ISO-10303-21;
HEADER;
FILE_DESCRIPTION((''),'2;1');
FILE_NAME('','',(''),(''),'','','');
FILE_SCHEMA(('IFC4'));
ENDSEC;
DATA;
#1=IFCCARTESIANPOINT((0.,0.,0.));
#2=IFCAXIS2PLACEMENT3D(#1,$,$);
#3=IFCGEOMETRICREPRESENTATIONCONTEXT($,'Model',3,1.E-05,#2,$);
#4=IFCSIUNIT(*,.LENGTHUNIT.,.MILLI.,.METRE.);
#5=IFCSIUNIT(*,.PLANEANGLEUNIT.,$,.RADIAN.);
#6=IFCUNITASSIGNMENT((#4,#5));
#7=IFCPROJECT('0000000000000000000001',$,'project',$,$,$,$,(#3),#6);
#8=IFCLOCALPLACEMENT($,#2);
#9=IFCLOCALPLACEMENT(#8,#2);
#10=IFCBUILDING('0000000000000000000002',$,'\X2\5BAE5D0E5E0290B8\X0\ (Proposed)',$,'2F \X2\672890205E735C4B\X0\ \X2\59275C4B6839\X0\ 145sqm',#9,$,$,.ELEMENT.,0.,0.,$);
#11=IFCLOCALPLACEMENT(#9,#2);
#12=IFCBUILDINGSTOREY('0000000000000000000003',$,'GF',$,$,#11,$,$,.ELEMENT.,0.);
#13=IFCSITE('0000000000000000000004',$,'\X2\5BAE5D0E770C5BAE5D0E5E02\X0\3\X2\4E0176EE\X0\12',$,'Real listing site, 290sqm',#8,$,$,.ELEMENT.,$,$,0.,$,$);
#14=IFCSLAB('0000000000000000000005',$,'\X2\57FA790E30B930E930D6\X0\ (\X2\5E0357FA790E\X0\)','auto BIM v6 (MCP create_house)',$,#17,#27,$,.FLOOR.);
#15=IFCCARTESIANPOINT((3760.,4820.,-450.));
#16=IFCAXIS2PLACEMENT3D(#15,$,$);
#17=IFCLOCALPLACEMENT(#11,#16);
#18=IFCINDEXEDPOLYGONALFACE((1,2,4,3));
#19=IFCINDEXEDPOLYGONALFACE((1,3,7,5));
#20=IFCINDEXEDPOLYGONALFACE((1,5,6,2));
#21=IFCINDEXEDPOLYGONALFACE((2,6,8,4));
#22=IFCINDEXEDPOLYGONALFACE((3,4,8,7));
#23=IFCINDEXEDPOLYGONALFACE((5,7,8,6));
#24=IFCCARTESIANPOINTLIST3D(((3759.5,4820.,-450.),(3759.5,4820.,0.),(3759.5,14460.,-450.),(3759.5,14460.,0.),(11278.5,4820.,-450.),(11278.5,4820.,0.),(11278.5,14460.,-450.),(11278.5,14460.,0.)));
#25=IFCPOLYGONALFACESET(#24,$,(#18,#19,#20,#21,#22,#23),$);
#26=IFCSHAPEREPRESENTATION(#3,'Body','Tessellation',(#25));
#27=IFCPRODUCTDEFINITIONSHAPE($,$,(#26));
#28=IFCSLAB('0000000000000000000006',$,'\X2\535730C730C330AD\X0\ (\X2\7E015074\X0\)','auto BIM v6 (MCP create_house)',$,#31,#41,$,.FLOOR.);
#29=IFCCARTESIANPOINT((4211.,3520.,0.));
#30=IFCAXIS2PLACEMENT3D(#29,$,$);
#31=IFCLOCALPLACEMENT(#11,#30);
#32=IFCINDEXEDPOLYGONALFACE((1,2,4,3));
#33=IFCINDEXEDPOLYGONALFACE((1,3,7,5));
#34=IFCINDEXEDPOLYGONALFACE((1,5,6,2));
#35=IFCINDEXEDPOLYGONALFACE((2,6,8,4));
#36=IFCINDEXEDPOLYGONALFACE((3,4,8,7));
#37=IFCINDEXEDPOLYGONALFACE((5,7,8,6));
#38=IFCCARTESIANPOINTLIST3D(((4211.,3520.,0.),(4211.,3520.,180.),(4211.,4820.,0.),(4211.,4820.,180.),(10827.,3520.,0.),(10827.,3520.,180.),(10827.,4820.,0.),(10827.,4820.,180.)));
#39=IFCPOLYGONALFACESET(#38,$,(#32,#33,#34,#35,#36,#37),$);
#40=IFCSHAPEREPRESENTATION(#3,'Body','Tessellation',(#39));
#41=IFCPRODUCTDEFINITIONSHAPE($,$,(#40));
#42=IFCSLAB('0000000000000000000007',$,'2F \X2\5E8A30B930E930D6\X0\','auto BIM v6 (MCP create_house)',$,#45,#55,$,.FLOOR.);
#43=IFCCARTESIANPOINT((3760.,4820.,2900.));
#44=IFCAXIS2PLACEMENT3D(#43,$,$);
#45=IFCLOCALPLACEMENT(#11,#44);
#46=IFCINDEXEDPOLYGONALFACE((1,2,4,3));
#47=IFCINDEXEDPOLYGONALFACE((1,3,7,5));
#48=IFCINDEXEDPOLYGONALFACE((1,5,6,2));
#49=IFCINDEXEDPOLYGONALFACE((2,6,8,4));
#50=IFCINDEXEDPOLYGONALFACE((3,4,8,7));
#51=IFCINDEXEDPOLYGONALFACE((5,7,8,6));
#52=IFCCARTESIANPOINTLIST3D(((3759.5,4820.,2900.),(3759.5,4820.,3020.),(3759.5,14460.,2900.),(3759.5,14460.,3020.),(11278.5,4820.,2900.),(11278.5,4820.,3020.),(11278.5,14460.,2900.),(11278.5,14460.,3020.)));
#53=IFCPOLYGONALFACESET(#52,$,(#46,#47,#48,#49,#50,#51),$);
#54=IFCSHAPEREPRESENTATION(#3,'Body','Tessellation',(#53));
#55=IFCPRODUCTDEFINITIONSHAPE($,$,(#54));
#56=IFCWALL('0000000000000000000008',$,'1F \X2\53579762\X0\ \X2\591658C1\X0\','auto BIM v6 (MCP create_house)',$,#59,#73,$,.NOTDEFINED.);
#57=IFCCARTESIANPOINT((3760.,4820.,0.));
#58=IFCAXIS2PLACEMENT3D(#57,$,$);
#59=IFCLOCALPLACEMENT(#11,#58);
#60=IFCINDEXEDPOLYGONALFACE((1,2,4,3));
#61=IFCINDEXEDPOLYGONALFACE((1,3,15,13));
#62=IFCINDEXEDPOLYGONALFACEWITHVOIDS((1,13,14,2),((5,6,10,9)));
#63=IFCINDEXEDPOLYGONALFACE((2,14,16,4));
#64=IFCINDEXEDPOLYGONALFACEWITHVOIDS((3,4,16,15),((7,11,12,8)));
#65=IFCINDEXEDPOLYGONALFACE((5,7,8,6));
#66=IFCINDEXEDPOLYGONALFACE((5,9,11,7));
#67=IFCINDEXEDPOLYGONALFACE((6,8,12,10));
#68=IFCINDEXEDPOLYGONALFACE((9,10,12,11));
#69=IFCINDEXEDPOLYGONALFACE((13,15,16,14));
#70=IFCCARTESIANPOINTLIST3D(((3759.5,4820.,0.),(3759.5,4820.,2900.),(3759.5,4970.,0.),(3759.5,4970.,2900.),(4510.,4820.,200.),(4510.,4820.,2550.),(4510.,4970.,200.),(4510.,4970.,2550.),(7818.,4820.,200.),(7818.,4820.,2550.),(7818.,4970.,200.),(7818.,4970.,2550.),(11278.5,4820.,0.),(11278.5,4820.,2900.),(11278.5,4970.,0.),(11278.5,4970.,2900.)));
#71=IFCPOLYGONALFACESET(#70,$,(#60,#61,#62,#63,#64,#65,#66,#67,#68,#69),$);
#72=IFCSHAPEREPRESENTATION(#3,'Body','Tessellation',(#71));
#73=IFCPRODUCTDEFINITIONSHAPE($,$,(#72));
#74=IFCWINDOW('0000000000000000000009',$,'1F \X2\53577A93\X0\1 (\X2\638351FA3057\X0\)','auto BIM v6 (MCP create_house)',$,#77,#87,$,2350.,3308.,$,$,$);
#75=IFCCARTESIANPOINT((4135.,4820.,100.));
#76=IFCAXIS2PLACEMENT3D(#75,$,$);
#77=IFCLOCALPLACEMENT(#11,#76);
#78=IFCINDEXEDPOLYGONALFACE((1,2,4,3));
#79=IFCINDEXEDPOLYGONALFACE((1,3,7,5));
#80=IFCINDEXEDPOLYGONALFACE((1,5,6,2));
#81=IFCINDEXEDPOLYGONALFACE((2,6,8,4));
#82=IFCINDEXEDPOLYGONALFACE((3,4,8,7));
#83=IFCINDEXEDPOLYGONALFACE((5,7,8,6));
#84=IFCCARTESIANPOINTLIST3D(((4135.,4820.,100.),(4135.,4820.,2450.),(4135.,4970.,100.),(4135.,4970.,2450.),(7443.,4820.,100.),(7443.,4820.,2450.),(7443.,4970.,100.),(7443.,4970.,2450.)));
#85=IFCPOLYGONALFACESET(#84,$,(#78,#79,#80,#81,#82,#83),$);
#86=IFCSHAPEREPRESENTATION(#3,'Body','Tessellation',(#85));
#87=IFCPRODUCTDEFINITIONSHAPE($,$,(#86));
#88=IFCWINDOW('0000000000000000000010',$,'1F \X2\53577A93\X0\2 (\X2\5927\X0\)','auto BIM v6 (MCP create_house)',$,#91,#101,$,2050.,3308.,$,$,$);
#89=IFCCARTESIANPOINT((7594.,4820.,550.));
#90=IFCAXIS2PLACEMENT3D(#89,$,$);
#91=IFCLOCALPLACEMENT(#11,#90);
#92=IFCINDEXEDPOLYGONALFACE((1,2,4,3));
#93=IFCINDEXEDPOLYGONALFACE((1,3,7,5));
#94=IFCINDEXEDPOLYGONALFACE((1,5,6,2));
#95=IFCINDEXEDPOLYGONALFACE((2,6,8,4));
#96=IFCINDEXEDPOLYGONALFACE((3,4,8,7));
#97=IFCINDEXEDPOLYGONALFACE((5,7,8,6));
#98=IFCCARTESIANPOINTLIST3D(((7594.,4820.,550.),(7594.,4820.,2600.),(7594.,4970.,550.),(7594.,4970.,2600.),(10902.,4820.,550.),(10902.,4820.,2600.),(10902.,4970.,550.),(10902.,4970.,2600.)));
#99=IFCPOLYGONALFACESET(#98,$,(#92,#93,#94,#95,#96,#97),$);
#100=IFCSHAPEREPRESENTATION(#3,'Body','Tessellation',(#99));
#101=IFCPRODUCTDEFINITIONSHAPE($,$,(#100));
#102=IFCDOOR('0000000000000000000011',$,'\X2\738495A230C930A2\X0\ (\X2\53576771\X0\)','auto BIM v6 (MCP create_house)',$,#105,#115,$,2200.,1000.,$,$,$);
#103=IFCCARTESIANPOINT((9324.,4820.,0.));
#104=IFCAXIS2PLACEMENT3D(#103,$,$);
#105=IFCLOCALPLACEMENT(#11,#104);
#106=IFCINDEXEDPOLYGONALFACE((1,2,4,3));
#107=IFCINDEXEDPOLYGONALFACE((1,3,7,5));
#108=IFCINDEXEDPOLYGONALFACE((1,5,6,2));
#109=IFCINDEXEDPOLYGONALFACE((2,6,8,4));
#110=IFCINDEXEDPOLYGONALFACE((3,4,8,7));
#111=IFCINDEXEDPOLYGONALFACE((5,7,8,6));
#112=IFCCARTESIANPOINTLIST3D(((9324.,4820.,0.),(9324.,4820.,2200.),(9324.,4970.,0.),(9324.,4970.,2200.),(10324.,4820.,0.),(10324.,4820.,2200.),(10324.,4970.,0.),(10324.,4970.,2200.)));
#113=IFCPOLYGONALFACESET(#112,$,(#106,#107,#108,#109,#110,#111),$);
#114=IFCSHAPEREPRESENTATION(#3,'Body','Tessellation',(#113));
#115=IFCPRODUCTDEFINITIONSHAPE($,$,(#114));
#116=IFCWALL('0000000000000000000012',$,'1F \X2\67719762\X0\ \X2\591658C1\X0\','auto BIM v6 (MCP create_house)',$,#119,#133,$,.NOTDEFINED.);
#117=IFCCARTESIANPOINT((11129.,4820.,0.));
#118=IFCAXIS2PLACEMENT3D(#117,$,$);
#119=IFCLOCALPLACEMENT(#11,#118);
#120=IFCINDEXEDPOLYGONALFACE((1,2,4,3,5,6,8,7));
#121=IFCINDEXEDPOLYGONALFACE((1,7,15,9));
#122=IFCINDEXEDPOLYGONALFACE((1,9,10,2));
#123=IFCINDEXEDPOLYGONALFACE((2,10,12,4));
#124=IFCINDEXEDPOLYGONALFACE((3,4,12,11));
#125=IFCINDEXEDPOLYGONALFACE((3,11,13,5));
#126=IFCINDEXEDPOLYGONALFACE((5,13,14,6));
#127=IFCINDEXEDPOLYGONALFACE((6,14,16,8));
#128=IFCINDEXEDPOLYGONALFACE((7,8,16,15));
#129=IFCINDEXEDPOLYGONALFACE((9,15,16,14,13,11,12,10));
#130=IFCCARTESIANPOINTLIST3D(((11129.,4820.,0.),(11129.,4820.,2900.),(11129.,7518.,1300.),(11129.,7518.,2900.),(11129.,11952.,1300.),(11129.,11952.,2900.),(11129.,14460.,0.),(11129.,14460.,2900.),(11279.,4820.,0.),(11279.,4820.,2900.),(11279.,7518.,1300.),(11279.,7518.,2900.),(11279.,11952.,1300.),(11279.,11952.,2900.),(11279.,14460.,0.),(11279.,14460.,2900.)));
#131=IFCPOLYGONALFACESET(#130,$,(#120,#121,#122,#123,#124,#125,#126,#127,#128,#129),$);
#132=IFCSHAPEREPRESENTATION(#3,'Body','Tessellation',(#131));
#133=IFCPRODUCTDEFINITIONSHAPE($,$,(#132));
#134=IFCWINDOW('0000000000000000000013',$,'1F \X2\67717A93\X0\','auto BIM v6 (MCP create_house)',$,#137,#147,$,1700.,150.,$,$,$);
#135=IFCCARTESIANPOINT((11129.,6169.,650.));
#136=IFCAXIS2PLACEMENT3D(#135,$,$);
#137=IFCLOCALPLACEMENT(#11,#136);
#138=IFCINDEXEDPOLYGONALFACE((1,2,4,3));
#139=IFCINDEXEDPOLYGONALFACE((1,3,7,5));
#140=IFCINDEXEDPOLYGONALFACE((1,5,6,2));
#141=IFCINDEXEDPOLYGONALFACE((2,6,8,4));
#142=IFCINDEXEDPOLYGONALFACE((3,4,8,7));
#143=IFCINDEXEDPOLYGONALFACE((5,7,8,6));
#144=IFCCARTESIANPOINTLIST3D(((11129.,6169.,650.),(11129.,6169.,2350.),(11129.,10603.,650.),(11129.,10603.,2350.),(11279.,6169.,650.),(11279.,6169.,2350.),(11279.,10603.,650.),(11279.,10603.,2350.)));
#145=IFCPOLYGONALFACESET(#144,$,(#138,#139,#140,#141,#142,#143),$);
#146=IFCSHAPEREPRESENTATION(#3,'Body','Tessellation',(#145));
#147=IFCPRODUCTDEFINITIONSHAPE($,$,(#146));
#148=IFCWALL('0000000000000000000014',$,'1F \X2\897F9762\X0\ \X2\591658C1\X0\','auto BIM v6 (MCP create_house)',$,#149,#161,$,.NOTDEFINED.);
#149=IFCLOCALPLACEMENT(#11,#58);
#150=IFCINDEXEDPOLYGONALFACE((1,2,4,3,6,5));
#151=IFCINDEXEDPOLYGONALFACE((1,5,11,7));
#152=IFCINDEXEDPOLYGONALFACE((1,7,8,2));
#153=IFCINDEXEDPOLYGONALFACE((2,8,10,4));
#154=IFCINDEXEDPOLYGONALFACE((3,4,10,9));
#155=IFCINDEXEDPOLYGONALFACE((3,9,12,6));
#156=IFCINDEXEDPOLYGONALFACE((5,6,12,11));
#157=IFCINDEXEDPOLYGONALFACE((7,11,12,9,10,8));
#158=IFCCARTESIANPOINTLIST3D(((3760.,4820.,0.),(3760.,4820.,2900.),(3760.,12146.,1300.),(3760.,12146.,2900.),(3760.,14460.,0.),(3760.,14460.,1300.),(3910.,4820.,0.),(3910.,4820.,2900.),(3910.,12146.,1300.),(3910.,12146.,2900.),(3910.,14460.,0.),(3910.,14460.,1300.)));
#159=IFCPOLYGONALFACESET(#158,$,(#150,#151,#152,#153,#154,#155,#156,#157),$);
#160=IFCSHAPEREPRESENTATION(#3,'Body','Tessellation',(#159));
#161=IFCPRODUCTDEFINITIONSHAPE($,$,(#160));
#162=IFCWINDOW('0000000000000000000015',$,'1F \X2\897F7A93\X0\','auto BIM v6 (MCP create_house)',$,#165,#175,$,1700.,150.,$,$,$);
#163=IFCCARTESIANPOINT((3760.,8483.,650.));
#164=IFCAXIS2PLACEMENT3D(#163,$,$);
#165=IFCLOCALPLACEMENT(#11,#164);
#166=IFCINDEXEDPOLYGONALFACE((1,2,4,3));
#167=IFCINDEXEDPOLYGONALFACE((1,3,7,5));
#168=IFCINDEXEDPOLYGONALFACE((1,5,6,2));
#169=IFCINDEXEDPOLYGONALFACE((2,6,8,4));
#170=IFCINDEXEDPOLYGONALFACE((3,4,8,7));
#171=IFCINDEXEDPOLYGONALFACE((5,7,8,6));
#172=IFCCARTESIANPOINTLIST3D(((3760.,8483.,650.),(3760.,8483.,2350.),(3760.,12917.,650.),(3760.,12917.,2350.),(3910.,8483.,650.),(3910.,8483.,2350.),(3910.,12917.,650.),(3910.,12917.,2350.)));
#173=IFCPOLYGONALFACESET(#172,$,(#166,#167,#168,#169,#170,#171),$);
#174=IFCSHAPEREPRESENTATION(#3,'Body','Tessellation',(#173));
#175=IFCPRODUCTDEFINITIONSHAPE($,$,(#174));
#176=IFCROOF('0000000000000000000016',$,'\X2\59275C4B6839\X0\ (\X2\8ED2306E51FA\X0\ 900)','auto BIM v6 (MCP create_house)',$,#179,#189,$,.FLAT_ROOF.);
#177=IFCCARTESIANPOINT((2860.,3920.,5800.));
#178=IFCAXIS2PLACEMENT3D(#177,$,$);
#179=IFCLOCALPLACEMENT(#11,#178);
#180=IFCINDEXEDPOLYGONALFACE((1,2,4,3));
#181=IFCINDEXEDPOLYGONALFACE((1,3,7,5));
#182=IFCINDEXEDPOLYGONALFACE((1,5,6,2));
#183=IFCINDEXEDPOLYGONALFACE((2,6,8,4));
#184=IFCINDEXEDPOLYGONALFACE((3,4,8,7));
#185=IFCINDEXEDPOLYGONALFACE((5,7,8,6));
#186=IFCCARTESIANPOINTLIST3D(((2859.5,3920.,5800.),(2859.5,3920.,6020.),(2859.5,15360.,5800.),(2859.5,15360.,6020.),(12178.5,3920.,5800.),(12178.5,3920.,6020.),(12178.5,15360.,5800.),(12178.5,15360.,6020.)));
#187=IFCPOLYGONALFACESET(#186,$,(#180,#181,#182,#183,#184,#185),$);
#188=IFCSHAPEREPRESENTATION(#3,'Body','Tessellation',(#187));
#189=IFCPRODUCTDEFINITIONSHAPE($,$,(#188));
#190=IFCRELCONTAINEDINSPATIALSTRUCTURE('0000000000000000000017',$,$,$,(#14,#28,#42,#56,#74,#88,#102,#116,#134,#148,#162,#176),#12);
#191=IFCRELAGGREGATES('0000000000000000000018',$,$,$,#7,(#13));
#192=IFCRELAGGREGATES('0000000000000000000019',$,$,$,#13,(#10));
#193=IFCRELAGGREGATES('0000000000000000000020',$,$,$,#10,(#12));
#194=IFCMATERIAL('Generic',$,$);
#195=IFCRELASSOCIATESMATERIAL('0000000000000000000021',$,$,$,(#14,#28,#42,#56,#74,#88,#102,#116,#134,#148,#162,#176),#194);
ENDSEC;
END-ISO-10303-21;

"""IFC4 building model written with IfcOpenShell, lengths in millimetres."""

from ifc_helpers import new_model, si_unit, frame, frame_2d, origin, place, context, project, spatial, rectangle, extrude, material, element, fill, save


model = new_model("IFC4")

# Units and contexts
model_context = context("Model", 3, precision=1e-05, world=origin())
ifc_project = project(units=[si_unit("LENGTHUNIT", "METRE", prefix="MILLI"), si_unit("PLANEANGLEUNIT", "RADIAN")], contexts=[model_context])

# Site, building, storey
site_placement = place(None, origin())
site = spatial("IfcSite", under=ifc_project, at=site_placement, Name="宮崎県宮崎市3丁目12", ObjectType="Real listing site, 290sqm", CompositionType="ELEMENT", RefElevation=0.0)
building_placement = place(site_placement, origin())
building = spatial("IfcBuilding", under=site, at=building_placement, Name="宮崎市邸 (Proposed)", ObjectType="2F 木造平屋 大屋根 145sqm", CompositionType="ELEMENT", ElevationOfRefHeight=0.0, ElevationOfTerrain=0.0)
storey_placement = place(building_placement, origin())
storey = spatial("IfcBuildingStorey", under=building, at=storey_placement, Name="GF", CompositionType="ELEMENT", Elevation=0.0)

# Slabs
ifc_material = material(Name="Generic")
slab_1_placement = place(storey_placement, frame((3760.0, 4820.0, -450.0)))
element("IfcSlab", 1, at=slab_1_placement, inside=storey, material=ifc_material, Name="基礎スラブ (布基礎)", Description="auto BIM v6 (MCP create_house)", PredefinedType="FLOOR", context=model_context, shape_type="SweptSolid", body=[
    extrude(rectangle(XDim=7519.0, YDim=9640.0, at=frame_2d((3759.0, 4820.0))), frame((3760.0, 4820.0, -450.0)), (0.0, 0.0, 1.0), 450.0),
])
slab_2_placement = place(storey_placement, frame((4211.0, 3520.0, 0.0)))
element("IfcSlab", 2, at=slab_2_placement, inside=storey, material=ifc_material, Name="南デッキ (縁側)", Description="auto BIM v6 (MCP create_house)", PredefinedType="FLOOR", context=model_context, shape_type="SweptSolid", body=[
    extrude(rectangle(XDim=6616.0, YDim=1300.0, at=frame_2d((3308.0, 650.0))), frame((4211.0, 3520.0, 0.0)), (0.0, 0.0, 1.0), 180.0),
])
slab_3_placement = place(storey_placement, frame((3760.0, 4820.0, 2900.0)))
element("IfcSlab", 3, at=slab_3_placement, inside=storey, material=ifc_material, Name="2F 床スラブ", Description="auto BIM v6 (MCP create_house)", PredefinedType="FLOOR", context=model_context, shape_type="SweptSolid", body=[
    extrude(rectangle(XDim=7519.0, YDim=9640.0, at=frame_2d((3759.0, 4820.0))), frame((3760.0, 4820.0, 2900.0)), (0.0, 0.0, 1.0), 120.0),
])

# Wall, openings, windows, door
wall_1_placement = place(storey_placement, frame((3760.0, 4820.0, 0.0)))
wall_1 = element("IfcWall", 4, at=wall_1_placement, inside=storey, material=ifc_material, Name="1F 南面 外壁", Description="auto BIM v6 (MCP create_house)", PredefinedType="NOTDEFINED", context=model_context, shape_type="SweptSolid", body=[
    extrude(rectangle(XDim=7519.0, YDim=150.0, at=frame_2d((3759.0, 75.0))), frame((3760.0, 4820.0, 0.0)), (0.0, 0.0, 1.0), 2900.0),
])
opening_1_placement = place(storey_placement, frame((4135.0, 4820.0, 100.0)))
opening_1 = element("IfcOpeningElement", 5, at=opening_1_placement, cuts=wall_1, PredefinedType="NOTDEFINED", context=model_context, shape_type="SweptSolid", body=[
    extrude(rectangle(XDim=3308.0, YDim=150.0, at=frame_2d((1654.0, 75.0))), frame((4135.0, 4820.0, 100.0)), (0.0, 0.0, 1.0), 2350.0),
])
opening_2_placement = place(storey_placement, frame((7594.0, 4820.0, 550.0)))
opening_2 = element("IfcOpeningElement", 6, at=opening_2_placement, cuts=wall_1, PredefinedType="NOTDEFINED", context=model_context, shape_type="SweptSolid", body=[
    extrude(rectangle(XDim=3308.0, YDim=150.0, at=frame_2d((1654.0, 75.0))), frame((7594.0, 4820.0, 550.0)), (0.0, 0.0, 1.0), 2050.0),
])
opening_3_placement = place(storey_placement, frame((9324.0, 4820.0, 0.0)))
opening_3 = element("IfcOpeningElement", 7, at=opening_3_placement, cuts=wall_1, PredefinedType="NOTDEFINED", context=model_context, shape_type="SweptSolid", body=[
    extrude(rectangle(XDim=1000.0, YDim=150.0, at=frame_2d((500.0, 75.0))), frame((9324.0, 4820.0, 0.0)), (0.0, 0.0, 1.0), 2200.0),
])
window_1_placement = place(storey_placement, frame((4135.0, 4820.0, 100.0)))
window_1 = element("IfcWindow", 8, at=window_1_placement, inside=storey, material=ifc_material, Name="1F 南窓1 (掃出し)", Description="auto BIM v6 (MCP create_house)", OverallHeight=2350.0, OverallWidth=3308.0, context=model_context, shape_type="SweptSolid", body=[
    extrude(rectangle(XDim=3308.0, YDim=150.0, at=frame_2d((1654.0, 75.0))), frame((4135.0, 4820.0, 100.0)), (0.0, 0.0, 1.0), 2350.0),
])
fill(opening_1, window_1)
window_2_placement = place(storey_placement, frame((7594.0, 4820.0, 550.0)))
window_2 = element("IfcWindow", 9, at=window_2_placement, inside=storey, material=ifc_material, Name="1F 南窓2 (大)", Description="auto BIM v6 (MCP create_house)", OverallHeight=2050.0, OverallWidth=3308.0, context=model_context, shape_type="SweptSolid", body=[
    extrude(rectangle(XDim=3308.0, YDim=150.0, at=frame_2d((1654.0, 75.0))), frame((7594.0, 4820.0, 550.0)), (0.0, 0.0, 1.0), 2050.0),
])
fill(opening_2, window_2)
door_placement = place(storey_placement, frame((9324.0, 4820.0, 0.0)))
door = element("IfcDoor", 10, at=door_placement, inside=storey, material=ifc_material, Name="玄関ドア (南東)", Description="auto BIM v6 (MCP create_house)", OverallHeight=2200.0, OverallWidth=1000.0, context=model_context, shape_type="SweptSolid", body=[
    extrude(rectangle(XDim=1000.0, YDim=150.0, at=frame_2d((500.0, 75.0))), frame((9324.0, 4820.0, 0.0)), (0.0, 0.0, 1.0), 2200.0),
])
fill(opening_3, door)

# Walls, openings, windows
wall_2_placement = place(storey_placement, frame((11129.0, 4820.0, 0.0)))
wall_2 = element("IfcWall", 11, at=wall_2_placement, inside=storey, material=ifc_material, Name="1F 東面 外壁", Description="auto BIM v6 (MCP create_house)", PredefinedType="NOTDEFINED", context=model_context, shape_type="SweptSolid", body=[
    extrude(rectangle(XDim=150.0, YDim=9640.0, at=frame_2d((75.0, 4820.0))), frame((11129.0, 4820.0, 0.0)), (0.0, 0.0, 1.0), 2900.0),
])
opening_4_placement = place(storey_placement, frame((11129.0, 6169.0, 650.0)))
opening_4 = element("IfcOpeningElement", 12, at=opening_4_placement, cuts=wall_2, PredefinedType="NOTDEFINED", context=model_context, shape_type="SweptSolid", body=[
    extrude(rectangle(XDim=150.0, YDim=4434.0, at=frame_2d((75.0, 2217.0))), frame((11129.0, 6169.0, 650.0)), (0.0, 0.0, 1.0), 1700.0),
])
window_3_placement = place(storey_placement, frame((11129.0, 6169.0, 650.0)))
window_3 = element("IfcWindow", 13, at=window_3_placement, inside=storey, material=ifc_material, Name="1F 東窓", Description="auto BIM v6 (MCP create_house)", OverallHeight=1700.0, OverallWidth=150.0, context=model_context, shape_type="SweptSolid", body=[
    extrude(rectangle(XDim=150.0, YDim=4434.0, at=frame_2d((75.0, 2217.0))), frame((11129.0, 6169.0, 650.0)), (0.0, 0.0, 1.0), 1700.0),
])
fill(opening_4, window_3)
wall_3_placement = place(storey_placement, frame((3760.0, 4820.0, 0.0)))
wall_3 = element("IfcWall", 14, at=wall_3_placement, inside=storey, material=ifc_material, Name="1F 西面 外壁", Description="auto BIM v6 (MCP create_house)", PredefinedType="NOTDEFINED", context=model_context, shape_type="SweptSolid", body=[
    extrude(rectangle(XDim=150.0, YDim=9640.0, at=frame_2d((75.0, 4820.0))), frame((3760.0, 4820.0, 0.0)), (0.0, 0.0, 1.0), 2900.0),
])
opening_5_placement = place(storey_placement, frame((3760.0, 8483.0, 650.0)))
opening_5 = element("IfcOpeningElement", 15, at=opening_5_placement, cuts=wall_3, PredefinedType="NOTDEFINED", context=model_context, shape_type="SweptSolid", body=[
    extrude(rectangle(XDim=150.0, YDim=4434.0, at=frame_2d((75.0, 2217.0))), frame((3760.0, 8483.0, 650.0)), (0.0, 0.0, 1.0), 1700.0),
])
window_4_placement = place(storey_placement, frame((3760.0, 8483.0, 650.0)))
window_4 = element("IfcWindow", 16, at=window_4_placement, inside=storey, material=ifc_material, Name="1F 西窓", Description="auto BIM v6 (MCP create_house)", OverallHeight=1700.0, OverallWidth=150.0, context=model_context, shape_type="SweptSolid", body=[
    extrude(rectangle(XDim=150.0, YDim=4434.0, at=frame_2d((75.0, 2217.0))), frame((3760.0, 8483.0, 650.0)), (0.0, 0.0, 1.0), 1700.0),
])
fill(opening_5, window_4)

# Roof
roof_placement = place(storey_placement, frame((2860.0, 3920.0, 5800.0)))
element("IfcRoof", 17, at=roof_placement, inside=storey, material=ifc_material, Name="大屋根 (軒の出 900)", Description="auto BIM v6 (MCP create_house)", PredefinedType="FLAT_ROOF", context=model_context, shape_type="SweptSolid", body=[
    extrude(rectangle(XDim=9319.0, YDim=11440.0, at=frame_2d((4659.0, 5720.0))), frame((2860.0, 3920.0, 5800.0)), (0.0, 0.0, 1.0), 220.0),
])

save(model, "model.ifc")
